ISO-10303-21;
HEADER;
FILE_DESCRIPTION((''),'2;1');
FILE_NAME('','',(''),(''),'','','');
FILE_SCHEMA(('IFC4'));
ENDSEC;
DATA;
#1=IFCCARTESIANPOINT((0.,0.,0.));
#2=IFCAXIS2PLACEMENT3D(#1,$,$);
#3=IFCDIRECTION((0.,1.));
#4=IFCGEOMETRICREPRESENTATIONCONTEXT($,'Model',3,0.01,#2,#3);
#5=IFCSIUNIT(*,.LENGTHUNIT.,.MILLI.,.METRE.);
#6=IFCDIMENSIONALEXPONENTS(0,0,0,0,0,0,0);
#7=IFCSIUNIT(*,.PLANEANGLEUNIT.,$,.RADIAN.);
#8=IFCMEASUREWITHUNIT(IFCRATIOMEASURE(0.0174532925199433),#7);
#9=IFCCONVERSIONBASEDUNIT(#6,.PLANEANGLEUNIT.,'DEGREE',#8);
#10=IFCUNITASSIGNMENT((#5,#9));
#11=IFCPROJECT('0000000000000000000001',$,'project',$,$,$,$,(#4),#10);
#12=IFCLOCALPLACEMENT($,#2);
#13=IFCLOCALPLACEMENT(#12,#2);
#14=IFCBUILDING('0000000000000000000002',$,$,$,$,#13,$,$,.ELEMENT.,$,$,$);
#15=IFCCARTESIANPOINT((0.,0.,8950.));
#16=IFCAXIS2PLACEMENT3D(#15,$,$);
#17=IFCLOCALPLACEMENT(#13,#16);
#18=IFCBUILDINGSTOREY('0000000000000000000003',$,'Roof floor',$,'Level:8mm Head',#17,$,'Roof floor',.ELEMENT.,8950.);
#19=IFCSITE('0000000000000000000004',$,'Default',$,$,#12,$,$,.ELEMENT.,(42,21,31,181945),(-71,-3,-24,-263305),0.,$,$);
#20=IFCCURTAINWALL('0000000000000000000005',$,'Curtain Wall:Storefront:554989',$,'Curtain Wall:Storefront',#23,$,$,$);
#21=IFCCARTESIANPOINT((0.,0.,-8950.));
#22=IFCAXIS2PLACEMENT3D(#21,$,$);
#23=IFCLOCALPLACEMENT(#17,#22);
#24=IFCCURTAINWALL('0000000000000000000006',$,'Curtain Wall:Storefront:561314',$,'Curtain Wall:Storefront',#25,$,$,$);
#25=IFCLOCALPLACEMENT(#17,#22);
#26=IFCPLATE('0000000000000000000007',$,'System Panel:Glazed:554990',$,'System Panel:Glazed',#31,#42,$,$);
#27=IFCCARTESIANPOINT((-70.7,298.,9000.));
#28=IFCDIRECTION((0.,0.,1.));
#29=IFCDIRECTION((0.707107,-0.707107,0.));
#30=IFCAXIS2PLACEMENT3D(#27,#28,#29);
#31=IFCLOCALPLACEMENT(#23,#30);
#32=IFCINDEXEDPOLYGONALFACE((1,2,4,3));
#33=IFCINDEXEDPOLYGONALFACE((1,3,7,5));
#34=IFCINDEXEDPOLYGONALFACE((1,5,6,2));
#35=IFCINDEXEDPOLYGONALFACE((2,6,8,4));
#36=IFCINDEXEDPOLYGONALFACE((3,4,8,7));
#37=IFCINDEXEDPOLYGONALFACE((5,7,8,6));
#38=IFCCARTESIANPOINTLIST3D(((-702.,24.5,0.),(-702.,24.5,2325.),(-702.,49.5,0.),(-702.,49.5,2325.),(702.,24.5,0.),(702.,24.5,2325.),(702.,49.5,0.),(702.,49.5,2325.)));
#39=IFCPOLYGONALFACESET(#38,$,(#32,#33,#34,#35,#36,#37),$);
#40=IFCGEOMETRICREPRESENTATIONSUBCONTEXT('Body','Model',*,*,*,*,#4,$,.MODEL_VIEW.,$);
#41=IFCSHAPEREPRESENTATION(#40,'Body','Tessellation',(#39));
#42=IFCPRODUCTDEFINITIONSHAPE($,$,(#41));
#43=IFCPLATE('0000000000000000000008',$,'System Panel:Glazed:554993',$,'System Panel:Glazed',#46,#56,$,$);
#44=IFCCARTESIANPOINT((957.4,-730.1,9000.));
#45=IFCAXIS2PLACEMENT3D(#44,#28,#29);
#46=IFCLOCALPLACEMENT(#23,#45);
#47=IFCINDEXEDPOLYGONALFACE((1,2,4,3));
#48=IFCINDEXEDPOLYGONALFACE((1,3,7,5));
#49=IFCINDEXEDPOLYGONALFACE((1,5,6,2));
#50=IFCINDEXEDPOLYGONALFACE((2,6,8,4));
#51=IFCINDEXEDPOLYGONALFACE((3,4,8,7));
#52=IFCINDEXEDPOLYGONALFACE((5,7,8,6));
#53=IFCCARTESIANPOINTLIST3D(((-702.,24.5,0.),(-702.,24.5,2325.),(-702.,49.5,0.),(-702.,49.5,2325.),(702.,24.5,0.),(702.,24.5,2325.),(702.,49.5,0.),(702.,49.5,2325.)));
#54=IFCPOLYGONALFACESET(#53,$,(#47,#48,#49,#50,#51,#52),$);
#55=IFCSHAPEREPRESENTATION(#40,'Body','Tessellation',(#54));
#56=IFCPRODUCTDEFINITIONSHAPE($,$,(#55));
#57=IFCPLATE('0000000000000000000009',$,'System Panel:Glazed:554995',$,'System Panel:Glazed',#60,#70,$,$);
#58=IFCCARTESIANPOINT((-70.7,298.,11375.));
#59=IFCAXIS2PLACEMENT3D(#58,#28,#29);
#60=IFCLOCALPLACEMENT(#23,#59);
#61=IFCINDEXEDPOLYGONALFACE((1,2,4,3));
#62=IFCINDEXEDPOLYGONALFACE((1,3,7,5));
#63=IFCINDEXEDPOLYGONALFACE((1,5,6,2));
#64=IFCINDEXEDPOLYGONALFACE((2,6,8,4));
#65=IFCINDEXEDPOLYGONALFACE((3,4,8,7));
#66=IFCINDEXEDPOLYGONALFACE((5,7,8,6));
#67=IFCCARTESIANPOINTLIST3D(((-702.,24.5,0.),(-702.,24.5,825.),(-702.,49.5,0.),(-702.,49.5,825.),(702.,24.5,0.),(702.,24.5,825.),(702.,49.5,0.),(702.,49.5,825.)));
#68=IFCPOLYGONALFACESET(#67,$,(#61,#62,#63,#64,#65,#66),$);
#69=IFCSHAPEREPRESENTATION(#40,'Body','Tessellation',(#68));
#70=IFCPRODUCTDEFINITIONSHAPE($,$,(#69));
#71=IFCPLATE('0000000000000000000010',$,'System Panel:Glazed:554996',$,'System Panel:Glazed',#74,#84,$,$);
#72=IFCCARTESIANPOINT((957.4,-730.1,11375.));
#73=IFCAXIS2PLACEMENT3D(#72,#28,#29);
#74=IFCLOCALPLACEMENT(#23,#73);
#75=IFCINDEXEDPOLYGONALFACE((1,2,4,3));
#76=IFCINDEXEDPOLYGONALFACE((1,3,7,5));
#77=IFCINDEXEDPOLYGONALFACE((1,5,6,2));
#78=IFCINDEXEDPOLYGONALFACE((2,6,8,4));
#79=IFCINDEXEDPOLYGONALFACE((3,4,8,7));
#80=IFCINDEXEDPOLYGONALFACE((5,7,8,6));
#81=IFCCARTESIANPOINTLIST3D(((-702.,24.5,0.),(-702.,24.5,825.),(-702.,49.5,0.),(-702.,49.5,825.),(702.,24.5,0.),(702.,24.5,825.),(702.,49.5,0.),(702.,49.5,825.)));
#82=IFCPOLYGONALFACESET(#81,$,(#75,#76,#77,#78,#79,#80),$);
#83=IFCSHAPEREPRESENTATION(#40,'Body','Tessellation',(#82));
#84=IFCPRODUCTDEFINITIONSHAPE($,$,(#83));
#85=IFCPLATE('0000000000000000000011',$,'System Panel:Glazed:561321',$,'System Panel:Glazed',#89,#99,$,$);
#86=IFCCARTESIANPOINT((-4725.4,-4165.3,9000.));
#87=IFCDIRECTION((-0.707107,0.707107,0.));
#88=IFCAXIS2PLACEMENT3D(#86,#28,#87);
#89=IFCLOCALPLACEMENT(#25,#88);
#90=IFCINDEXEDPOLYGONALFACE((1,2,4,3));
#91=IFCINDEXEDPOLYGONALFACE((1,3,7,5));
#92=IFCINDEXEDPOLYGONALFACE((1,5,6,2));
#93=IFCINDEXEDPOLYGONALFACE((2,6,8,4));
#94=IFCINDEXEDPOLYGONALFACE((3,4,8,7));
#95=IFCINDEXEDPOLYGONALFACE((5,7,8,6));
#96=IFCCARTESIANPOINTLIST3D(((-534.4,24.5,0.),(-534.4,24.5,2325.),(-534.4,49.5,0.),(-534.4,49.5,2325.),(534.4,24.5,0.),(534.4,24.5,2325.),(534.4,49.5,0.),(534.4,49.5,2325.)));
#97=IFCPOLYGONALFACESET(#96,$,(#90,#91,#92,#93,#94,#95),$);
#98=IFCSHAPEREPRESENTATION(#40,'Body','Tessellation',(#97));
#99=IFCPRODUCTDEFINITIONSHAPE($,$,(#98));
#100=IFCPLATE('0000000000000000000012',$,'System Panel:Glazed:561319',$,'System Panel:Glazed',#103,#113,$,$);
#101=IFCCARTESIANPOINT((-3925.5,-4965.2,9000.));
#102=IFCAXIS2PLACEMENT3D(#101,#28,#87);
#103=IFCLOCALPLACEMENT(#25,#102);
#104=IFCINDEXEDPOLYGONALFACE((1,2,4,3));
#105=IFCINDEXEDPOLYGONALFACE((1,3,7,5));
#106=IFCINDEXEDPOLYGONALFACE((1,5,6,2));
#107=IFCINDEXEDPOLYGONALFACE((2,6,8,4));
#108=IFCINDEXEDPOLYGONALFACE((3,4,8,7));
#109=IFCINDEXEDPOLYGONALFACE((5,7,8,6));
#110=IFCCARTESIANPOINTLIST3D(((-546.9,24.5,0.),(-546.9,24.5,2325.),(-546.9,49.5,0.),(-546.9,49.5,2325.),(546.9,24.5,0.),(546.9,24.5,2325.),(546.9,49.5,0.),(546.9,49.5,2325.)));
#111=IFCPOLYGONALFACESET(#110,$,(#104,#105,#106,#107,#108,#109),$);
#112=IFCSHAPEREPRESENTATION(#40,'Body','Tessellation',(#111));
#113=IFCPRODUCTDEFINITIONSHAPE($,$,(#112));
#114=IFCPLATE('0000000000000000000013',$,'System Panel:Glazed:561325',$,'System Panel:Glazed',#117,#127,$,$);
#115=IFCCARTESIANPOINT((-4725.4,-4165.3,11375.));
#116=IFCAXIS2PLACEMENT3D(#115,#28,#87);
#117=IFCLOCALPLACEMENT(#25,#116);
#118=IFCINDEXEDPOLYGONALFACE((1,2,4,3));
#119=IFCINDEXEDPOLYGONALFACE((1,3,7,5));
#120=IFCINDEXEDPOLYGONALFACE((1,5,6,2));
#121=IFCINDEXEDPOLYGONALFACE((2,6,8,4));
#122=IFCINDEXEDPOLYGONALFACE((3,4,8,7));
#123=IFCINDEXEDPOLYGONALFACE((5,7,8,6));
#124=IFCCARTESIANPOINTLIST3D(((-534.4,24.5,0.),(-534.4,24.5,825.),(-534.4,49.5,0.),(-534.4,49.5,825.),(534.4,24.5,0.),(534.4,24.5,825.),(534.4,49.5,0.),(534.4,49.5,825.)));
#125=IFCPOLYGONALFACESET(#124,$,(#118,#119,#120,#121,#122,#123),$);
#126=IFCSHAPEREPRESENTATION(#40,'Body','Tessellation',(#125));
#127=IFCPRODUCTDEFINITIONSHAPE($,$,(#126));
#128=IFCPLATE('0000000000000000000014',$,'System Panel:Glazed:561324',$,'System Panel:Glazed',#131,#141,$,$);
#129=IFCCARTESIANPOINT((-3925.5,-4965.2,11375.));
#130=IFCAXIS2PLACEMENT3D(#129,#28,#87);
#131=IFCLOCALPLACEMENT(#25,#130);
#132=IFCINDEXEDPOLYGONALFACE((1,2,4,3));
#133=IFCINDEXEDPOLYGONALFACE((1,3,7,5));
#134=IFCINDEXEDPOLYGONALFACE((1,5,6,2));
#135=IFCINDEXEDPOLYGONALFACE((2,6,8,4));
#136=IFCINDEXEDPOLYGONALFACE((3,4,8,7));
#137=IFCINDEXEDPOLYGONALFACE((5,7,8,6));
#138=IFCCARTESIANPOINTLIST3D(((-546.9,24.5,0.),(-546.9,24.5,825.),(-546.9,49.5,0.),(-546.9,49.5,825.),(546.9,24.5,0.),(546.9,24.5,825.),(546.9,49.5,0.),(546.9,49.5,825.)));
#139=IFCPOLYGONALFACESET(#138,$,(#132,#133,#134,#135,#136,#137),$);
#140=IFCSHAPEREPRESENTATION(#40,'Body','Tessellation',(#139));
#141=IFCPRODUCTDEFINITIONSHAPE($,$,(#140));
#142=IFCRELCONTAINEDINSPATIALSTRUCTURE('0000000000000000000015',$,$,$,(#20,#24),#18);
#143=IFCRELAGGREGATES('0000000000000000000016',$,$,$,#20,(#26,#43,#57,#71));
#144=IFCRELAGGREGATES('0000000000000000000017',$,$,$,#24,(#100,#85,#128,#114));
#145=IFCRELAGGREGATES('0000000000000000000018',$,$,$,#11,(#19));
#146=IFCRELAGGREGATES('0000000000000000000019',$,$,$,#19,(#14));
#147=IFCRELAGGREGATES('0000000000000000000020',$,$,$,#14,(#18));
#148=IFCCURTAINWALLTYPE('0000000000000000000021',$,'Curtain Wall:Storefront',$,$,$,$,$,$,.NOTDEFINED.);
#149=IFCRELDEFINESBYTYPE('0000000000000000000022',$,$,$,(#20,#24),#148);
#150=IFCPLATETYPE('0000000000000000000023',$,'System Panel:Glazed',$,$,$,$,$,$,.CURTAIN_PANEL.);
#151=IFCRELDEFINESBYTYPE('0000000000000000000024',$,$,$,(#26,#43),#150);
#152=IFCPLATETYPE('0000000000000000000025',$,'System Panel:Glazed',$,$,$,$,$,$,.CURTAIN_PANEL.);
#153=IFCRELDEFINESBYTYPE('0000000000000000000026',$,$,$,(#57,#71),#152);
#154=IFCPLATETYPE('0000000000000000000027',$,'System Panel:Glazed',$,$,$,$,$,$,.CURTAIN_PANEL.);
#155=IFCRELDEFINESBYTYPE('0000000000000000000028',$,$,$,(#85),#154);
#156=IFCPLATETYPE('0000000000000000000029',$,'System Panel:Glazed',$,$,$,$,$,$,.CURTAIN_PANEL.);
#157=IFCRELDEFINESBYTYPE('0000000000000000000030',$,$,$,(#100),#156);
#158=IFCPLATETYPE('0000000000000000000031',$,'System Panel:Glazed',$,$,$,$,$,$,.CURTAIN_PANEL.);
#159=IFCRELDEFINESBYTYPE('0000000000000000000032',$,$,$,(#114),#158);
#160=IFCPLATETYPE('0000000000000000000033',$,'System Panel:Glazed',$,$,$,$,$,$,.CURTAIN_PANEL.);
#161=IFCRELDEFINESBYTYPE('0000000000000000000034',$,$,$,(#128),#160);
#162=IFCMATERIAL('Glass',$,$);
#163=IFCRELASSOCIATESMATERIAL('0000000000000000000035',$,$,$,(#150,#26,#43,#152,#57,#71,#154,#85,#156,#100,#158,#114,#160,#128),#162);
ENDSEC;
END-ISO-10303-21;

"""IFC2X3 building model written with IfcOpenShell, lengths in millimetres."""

from ifc_helpers import new_model, entity, si_unit, converted_unit, direction, frame, frame_2d, origin, origin_2d_with_axis, place, context, subcontext, project, spatial, rectangle, extrude, source, transform, mapped, material, type_object, type_shapes, element, aggregate, save


model = new_model("IFC2X3")

# Units and contexts
model_context = context("Model", 3, precision=0.01, world=origin(), true_north=direction((0.0, 1.0)))
body_context = subcontext(model_context, "Body", "Model", "MODEL_VIEW")
ifc_project = project(units=[si_unit("LENGTHUNIT", "METRE", prefix="MILLI"), converted_unit("PLANEANGLEUNIT", "DEGREE", entity("IfcRatioMeasure", 0.0174532925199433), si_unit("PLANEANGLEUNIT", "RADIAN"), dimensions=[0, 0, 0, 0, 0, 0, 0])], contexts=[model_context])

# Site, building, storey
site_placement = place(None, origin())
site = spatial("IfcSite", under=ifc_project, at=site_placement, Name="Default", CompositionType="ELEMENT", RefLatitude=(42, 21, 31, 181945), RefLongitude=(-71, -3, -24, -263305), RefElevation=0.0)
building_placement = place(site_placement, origin())
building = spatial("IfcBuilding", under=site, at=building_placement, CompositionType="ELEMENT")
storey_placement = place(building_placement, frame((0.0, 0.0, 8950.0)))
storey = spatial("IfcBuildingStorey", under=building, at=storey_placement, Name="Roof floor", ObjectType="Level:8mm Head", LongName="Roof floor", CompositionType="ELEMENT", Elevation=8950.0)

# Curtain walls
curtain_wall_type = type_object("IfcCurtainWallType", Name="Curtain Wall:Storefront", PredefinedType="NOTDEFINED")
curtain_wall_1_placement = place(storey_placement, frame((0.0, 0.0, -8950.0)))
curtain_wall_1 = element("IfcCurtainWall", 1, at=curtain_wall_1_placement, inside=storey, type_object=curtain_wall_type, Name="Curtain Wall:Storefront:554989", ObjectType="Curtain Wall:Storefront")
curtain_wall_2_placement = place(storey_placement, frame((0.0, 0.0, -8950.0)))
curtain_wall_2 = element("IfcCurtainWall", 2, at=curtain_wall_2_placement, inside=storey, type_object=curtain_wall_type, Name="Curtain Wall:Storefront:561314", ObjectType="Curtain Wall:Storefront")

# Plates
ifc_material_1 = material(Name="Glass")
plate_type_1 = type_object("IfcPlateType", Name="System Panel:Glazed", PredefinedType="CURTAIN_PANEL", material=ifc_material_1)
shared_shape_1 = source(origin(), body_context, "Body", "SweptSolid", [
    extrude(rectangle(XDim=25.0, YDim=1403.9, at=frame_2d((0.0, 0.0), x_axis=(1.0, 0.0))), frame((0.0, 37.0, 0.0), z_axis=(0.0, 0.0, 1.0), x_axis=(0.0, 1.0, 0.0)), (0.0, 0.0, 1.0), 2325.0),
])
type_shapes(plate_type_1, [shared_shape_1])
plate_1_placement = place(curtain_wall_1_placement, frame((-70.7, 298.0, 9000.0), z_axis=(0.0, 0.0, 1.0), x_axis=(0.707107, -0.707107, 0.0)))
plate_1 = element("IfcPlate", 3, at=plate_1_placement, type_object=plate_type_1, material=ifc_material_1, Name="System Panel:Glazed:554990", ObjectType="System Panel:Glazed", context=body_context, shape_type="MappedRepresentation", body=[
    mapped(shared_shape_1, transform((0.0, 0.0, 0.0), scale=1.0)),
])
plate_2_placement = place(curtain_wall_1_placement, frame((957.4, -730.1, 9000.0), z_axis=(0.0, 0.0, 1.0), x_axis=(0.707107, -0.707107, 0.0)))
plate_2 = element("IfcPlate", 4, at=plate_2_placement, type_object=plate_type_1, material=ifc_material_1, Name="System Panel:Glazed:554993", ObjectType="System Panel:Glazed", context=body_context, shape_type="MappedRepresentation", body=[
    mapped(shared_shape_1, transform((0.0, 0.0, 0.0), scale=1.0)),
])
plate_type_2 = type_object("IfcPlateType", Name="System Panel:Glazed", PredefinedType="CURTAIN_PANEL", material=ifc_material_1)
shared_shape_2 = source(origin(), body_context, "Body", "SweptSolid", [
    extrude(rectangle(XDim=25.0, YDim=1403.9, at=frame_2d((0.0, 0.0), x_axis=(1.0, 0.0))), frame((0.0, 37.0, 0.0), z_axis=(0.0, 0.0, 1.0), x_axis=(0.0, 1.0, 0.0)), (0.0, 0.0, 1.0), 825.0),
])
type_shapes(plate_type_2, [shared_shape_2])
plate_3_placement = place(curtain_wall_1_placement, frame((-70.7, 298.0, 11375.0), z_axis=(0.0, 0.0, 1.0), x_axis=(0.707107, -0.707107, 0.0)))
plate_3 = element("IfcPlate", 5, at=plate_3_placement, type_object=plate_type_2, material=ifc_material_1, Name="System Panel:Glazed:554995", ObjectType="System Panel:Glazed", context=body_context, shape_type="MappedRepresentation", body=[
    mapped(shared_shape_2, transform((0.0, 0.0, 0.0), scale=1.0)),
])
plate_4_placement = place(curtain_wall_1_placement, frame((957.4, -730.1, 11375.0), z_axis=(0.0, 0.0, 1.0), x_axis=(0.707107, -0.707107, 0.0)))
plate_4 = element("IfcPlate", 6, at=plate_4_placement, type_object=plate_type_2, material=ifc_material_1, Name="System Panel:Glazed:554996", ObjectType="System Panel:Glazed", context=body_context, shape_type="MappedRepresentation", body=[
    mapped(shared_shape_2, transform((0.0, 0.0, 0.0), scale=1.0)),
])
aggregate(curtain_wall_1, [plate_1, plate_2, plate_3, plate_4])
plate_type_3 = type_object("IfcPlateType", Name="System Panel:Glazed", PredefinedType="CURTAIN_PANEL", material=ifc_material_1)
shared_shape_3 = source(origin(), body_context, "Body", "SweptSolid", [
    extrude(rectangle(XDim=25.0, YDim=1068.7, at=frame_2d((0.0, 0.0), x_axis=(1.0, 0.0))), frame((0.0, 37.0, 0.0), z_axis=(0.0, 0.0, 1.0), x_axis=(0.0, 1.0, 0.0)), (0.0, 0.0, 1.0), 2325.0),
])
type_shapes(plate_type_3, [shared_shape_3])
plate_5_placement = place(curtain_wall_2_placement, frame((-4725.4, -4165.3, 9000.0), z_axis=(0.0, 0.0, 1.0), x_axis=(-0.707107, 0.707107, 0.0)))
plate_5 = element("IfcPlate", 7, at=plate_5_placement, type_object=plate_type_3, material=ifc_material_1, Name="System Panel:Glazed:561321", ObjectType="System Panel:Glazed", context=body_context, shape_type="MappedRepresentation", body=[
    mapped(shared_shape_3, transform((0.0, 0.0, 0.0), scale=1.0)),
])
plate_type_4 = type_object("IfcPlateType", Name="System Panel:Glazed", PredefinedType="CURTAIN_PANEL", material=ifc_material_1)
shared_shape_4 = source(origin(), body_context, "Body", "SweptSolid", [
    extrude(rectangle(XDim=25.0, YDim=1093.7, at=origin_2d_with_axis()), frame((0.0, 37.0, 0.0), z_axis=(0.0, 0.0, 1.0), x_axis=(0.0, 1.0, 0.0)), (0.0, 0.0, 1.0), 2325.0),
])
type_shapes(plate_type_4, [shared_shape_4])
plate_6_placement = place(curtain_wall_2_placement, frame((-3925.5, -4965.2, 9000.0), z_axis=(0.0, 0.0, 1.0), x_axis=(-0.707107, 0.707107, 0.0)))
plate_6 = element("IfcPlate", 8, at=plate_6_placement, type_object=plate_type_4, material=ifc_material_1, Name="System Panel:Glazed:561319", ObjectType="System Panel:Glazed", context=body_context, shape_type="MappedRepresentation", body=[
    mapped(shared_shape_4, transform((0.0, 0.0, 0.0), scale=1.0)),
])
plate_type_5 = type_object("IfcPlateType", Name="System Panel:Glazed", PredefinedType="CURTAIN_PANEL", material=ifc_material_1)
shared_shape_5 = source(origin(), body_context, "Body", "SweptSolid", [
    extrude(rectangle(XDim=25.0, YDim=1068.7, at=frame_2d((0.0, 0.0), x_axis=(1.0, 0.0))), frame((0.0, 37.0, 0.0), z_axis=(0.0, 0.0, 1.0), x_axis=(0.0, 1.0, 0.0)), (0.0, 0.0, 1.0), 825.0),
])
type_shapes(plate_type_5, [shared_shape_5])
plate_7_placement = place(curtain_wall_2_placement, frame((-4725.4, -4165.3, 11375.0), z_axis=(0.0, 0.0, 1.0), x_axis=(-0.707107, 0.707107, 0.0)))
plate_7 = element("IfcPlate", 9, at=plate_7_placement, type_object=plate_type_5, material=ifc_material_1, Name="System Panel:Glazed:561325", ObjectType="System Panel:Glazed", context=body_context, shape_type="MappedRepresentation", body=[
    mapped(shared_shape_5, transform((0.0, 0.0, 0.0), scale=1.0)),
])
plate_type_6 = type_object("IfcPlateType", Name="System Panel:Glazed", PredefinedType="CURTAIN_PANEL", material=ifc_material_1)
shared_shape_6 = source(origin(), body_context, "Body", "SweptSolid", [
    extrude(rectangle(XDim=25.0, YDim=1093.7, at=origin_2d_with_axis()), frame((0.0, 37.0, 0.0), z_axis=(0.0, 0.0, 1.0), x_axis=(0.0, 1.0, 0.0)), (0.0, 0.0, 1.0), 825.0),
])
type_shapes(plate_type_6, [shared_shape_6])
plate_8_placement = place(curtain_wall_2_placement, frame((-3925.5, -4965.2, 11375.0), z_axis=(0.0, 0.0, 1.0), x_axis=(-0.707107, 0.707107, 0.0)))
plate_8 = element("IfcPlate", 10, at=plate_8_placement, type_object=plate_type_6, material=ifc_material_1, Name="System Panel:Glazed:561324", ObjectType="System Panel:Glazed", context=body_context, shape_type="MappedRepresentation", body=[
    mapped(shared_shape_6, transform((0.0, 0.0, 0.0), scale=1.0)),
])
aggregate(curtain_wall_2, [plate_6, plate_5, plate_8, plate_7])

save(model, "model.ifc")
